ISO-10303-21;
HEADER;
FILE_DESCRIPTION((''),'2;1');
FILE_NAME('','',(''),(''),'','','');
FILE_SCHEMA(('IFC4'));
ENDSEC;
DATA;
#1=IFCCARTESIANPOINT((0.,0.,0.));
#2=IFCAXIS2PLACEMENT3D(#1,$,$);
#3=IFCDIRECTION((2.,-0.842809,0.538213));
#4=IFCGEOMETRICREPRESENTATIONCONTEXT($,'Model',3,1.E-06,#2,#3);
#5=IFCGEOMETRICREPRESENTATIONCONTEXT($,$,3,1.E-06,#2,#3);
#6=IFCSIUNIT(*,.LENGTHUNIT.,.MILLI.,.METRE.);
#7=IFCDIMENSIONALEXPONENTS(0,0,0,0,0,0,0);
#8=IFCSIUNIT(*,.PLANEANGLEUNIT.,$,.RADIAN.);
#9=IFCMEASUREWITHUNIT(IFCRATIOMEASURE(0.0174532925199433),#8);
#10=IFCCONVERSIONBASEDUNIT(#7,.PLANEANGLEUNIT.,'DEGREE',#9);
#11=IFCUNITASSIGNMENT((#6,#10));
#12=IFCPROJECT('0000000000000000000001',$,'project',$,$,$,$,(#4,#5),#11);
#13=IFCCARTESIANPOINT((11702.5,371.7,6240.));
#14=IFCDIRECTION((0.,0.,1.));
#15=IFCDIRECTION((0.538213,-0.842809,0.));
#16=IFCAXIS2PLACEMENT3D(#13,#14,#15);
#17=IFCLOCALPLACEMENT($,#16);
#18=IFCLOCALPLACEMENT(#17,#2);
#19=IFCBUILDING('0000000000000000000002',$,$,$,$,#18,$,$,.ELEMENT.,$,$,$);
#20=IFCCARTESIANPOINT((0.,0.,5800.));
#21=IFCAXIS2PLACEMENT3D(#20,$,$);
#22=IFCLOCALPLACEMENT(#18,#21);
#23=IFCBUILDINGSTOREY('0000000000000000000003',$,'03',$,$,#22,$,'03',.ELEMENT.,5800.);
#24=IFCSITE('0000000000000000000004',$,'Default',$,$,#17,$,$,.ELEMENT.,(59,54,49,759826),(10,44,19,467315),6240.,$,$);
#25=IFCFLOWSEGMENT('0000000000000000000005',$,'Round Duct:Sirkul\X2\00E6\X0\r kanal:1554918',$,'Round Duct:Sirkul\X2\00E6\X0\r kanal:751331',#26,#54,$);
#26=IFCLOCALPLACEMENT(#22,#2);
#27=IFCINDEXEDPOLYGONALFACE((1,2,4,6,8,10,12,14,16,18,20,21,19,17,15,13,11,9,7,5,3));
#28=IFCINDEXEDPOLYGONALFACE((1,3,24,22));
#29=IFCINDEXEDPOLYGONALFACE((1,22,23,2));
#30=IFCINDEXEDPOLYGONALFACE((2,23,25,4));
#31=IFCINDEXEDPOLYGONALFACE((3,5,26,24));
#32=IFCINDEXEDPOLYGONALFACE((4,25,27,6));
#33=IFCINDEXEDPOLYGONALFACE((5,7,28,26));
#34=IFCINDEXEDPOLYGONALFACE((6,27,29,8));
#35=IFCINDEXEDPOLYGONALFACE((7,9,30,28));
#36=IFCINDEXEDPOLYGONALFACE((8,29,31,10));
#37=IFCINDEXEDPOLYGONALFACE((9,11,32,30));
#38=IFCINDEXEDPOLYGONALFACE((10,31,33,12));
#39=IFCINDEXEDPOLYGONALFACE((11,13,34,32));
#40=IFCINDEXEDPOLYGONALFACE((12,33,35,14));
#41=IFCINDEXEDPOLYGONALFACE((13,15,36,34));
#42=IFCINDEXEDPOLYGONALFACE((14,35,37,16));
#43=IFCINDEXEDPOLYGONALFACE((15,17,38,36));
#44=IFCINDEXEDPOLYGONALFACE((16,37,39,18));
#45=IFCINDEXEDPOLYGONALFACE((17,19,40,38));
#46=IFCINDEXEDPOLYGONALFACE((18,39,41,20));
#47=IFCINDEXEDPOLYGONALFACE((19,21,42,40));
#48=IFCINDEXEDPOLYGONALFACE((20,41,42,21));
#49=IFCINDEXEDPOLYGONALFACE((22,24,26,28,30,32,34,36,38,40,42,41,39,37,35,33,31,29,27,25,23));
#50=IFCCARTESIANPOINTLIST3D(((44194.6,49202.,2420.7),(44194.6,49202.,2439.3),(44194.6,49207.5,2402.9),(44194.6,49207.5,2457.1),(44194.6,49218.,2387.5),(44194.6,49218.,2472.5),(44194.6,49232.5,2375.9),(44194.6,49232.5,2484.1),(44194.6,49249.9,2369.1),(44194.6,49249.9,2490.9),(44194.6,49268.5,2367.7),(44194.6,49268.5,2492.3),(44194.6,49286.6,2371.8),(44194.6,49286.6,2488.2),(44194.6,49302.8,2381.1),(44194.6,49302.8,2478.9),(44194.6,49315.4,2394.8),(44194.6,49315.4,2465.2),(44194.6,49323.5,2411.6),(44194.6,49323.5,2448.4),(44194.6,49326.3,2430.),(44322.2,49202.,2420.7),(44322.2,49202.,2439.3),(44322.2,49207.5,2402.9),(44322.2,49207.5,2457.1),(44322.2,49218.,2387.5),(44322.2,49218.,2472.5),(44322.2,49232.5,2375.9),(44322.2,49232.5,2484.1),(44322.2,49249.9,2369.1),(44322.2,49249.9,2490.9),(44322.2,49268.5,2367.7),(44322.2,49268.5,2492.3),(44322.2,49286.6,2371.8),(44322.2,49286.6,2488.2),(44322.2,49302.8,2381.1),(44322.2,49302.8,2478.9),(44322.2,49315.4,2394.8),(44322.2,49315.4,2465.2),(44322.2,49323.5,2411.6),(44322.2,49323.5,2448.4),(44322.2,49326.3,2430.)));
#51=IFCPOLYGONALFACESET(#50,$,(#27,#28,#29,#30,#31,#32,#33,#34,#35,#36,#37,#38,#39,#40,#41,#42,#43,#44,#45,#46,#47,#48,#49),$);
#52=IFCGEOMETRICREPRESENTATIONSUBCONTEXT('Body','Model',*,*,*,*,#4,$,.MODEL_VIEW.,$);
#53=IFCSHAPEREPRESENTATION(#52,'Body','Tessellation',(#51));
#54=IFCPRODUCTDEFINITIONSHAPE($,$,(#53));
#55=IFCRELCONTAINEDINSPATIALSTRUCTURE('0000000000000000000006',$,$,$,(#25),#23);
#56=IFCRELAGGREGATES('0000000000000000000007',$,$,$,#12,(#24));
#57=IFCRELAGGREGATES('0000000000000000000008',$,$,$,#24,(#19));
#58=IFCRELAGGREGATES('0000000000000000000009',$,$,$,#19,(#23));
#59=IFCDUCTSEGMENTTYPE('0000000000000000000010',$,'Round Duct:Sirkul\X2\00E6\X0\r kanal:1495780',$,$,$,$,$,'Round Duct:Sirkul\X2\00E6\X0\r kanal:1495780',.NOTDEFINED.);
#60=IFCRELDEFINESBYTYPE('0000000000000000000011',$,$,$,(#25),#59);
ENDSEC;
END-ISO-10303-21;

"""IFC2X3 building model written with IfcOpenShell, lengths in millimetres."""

from ifc_helpers import new_model, entity, si_unit, converted_unit, direction, frame, origin, origin_2d_with_axis, place, context, subcontext, project, spatial, circle, extrude, type_object, element, save


model = new_model("IFC2X3")

# Units and contexts
model_context = context("Model", 3, precision=1e-06, world=origin(), true_north=direction((2.0, -0.842809, 0.538213)))
context_of_model = context(None, 3, precision=1e-06, world=origin(), true_north=direction((2.0, -0.842809, 0.538213)))
body_context = subcontext(model_context, "Body", "Model", "MODEL_VIEW")
ifc_project = project(units=[si_unit("LENGTHUNIT", "METRE", prefix="MILLI"), converted_unit("PLANEANGLEUNIT", "DEGREE", entity("IfcRatioMeasure", 0.0174532925199433), si_unit("PLANEANGLEUNIT", "RADIAN"), dimensions=[0, 0, 0, 0, 0, 0, 0])], contexts=[model_context, context_of_model])

# Site, building, storey
site_placement = place(None, frame((11702.5, 371.7, 6240.0), z_axis=(0.0, 0.0, 1.0), x_axis=(0.538213, -0.842809, 0.0)))
site = spatial("IfcSite", under=ifc_project, at=site_placement, Name="Default", CompositionType="ELEMENT", RefLatitude=(59, 54, 49, 759826), RefLongitude=(10, 44, 19, 467315), RefElevation=6240.0)
building_placement = place(site_placement, origin())
building = spatial("IfcBuilding", under=site, at=building_placement, CompositionType="ELEMENT")
storey_placement = place(building_placement, frame((0.0, 0.0, 5800.0)))
storey = spatial("IfcBuildingStorey", under=building, at=storey_placement, Name="03", LongName="03", CompositionType="ELEMENT", Elevation=5800.0)

# Flow segment
duct_segment_type_1 = type_object("IfcDuctSegmentType", Name="Round Duct:Sirkulær kanal:1495780", ElementType="Round Duct:Sirkulær kanal:1495780", PredefinedType="NOTDEFINED")
flow_segment_1_placement = place(storey_placement, origin())
element("IfcFlowSegment", 1, at=flow_segment_1_placement, inside=storey, type_object=duct_segment_type_1, Name="Round Duct:Sirkulær kanal:1554918", ObjectType="Round Duct:Sirkulær kanal:751331", context=body_context, shape_type="SweptSolid", body=[
    extrude(circle(Radius=62.5, at=origin_2d_with_axis()), frame((44194.6, 49263.8, 2430.0), z_axis=(1.0, 0.0, 0.0), x_axis=(0.0, 1.0, 0.0)), (0.0, 0.0, 1.0), 127.6),
])

save(model, "model.ifc")
